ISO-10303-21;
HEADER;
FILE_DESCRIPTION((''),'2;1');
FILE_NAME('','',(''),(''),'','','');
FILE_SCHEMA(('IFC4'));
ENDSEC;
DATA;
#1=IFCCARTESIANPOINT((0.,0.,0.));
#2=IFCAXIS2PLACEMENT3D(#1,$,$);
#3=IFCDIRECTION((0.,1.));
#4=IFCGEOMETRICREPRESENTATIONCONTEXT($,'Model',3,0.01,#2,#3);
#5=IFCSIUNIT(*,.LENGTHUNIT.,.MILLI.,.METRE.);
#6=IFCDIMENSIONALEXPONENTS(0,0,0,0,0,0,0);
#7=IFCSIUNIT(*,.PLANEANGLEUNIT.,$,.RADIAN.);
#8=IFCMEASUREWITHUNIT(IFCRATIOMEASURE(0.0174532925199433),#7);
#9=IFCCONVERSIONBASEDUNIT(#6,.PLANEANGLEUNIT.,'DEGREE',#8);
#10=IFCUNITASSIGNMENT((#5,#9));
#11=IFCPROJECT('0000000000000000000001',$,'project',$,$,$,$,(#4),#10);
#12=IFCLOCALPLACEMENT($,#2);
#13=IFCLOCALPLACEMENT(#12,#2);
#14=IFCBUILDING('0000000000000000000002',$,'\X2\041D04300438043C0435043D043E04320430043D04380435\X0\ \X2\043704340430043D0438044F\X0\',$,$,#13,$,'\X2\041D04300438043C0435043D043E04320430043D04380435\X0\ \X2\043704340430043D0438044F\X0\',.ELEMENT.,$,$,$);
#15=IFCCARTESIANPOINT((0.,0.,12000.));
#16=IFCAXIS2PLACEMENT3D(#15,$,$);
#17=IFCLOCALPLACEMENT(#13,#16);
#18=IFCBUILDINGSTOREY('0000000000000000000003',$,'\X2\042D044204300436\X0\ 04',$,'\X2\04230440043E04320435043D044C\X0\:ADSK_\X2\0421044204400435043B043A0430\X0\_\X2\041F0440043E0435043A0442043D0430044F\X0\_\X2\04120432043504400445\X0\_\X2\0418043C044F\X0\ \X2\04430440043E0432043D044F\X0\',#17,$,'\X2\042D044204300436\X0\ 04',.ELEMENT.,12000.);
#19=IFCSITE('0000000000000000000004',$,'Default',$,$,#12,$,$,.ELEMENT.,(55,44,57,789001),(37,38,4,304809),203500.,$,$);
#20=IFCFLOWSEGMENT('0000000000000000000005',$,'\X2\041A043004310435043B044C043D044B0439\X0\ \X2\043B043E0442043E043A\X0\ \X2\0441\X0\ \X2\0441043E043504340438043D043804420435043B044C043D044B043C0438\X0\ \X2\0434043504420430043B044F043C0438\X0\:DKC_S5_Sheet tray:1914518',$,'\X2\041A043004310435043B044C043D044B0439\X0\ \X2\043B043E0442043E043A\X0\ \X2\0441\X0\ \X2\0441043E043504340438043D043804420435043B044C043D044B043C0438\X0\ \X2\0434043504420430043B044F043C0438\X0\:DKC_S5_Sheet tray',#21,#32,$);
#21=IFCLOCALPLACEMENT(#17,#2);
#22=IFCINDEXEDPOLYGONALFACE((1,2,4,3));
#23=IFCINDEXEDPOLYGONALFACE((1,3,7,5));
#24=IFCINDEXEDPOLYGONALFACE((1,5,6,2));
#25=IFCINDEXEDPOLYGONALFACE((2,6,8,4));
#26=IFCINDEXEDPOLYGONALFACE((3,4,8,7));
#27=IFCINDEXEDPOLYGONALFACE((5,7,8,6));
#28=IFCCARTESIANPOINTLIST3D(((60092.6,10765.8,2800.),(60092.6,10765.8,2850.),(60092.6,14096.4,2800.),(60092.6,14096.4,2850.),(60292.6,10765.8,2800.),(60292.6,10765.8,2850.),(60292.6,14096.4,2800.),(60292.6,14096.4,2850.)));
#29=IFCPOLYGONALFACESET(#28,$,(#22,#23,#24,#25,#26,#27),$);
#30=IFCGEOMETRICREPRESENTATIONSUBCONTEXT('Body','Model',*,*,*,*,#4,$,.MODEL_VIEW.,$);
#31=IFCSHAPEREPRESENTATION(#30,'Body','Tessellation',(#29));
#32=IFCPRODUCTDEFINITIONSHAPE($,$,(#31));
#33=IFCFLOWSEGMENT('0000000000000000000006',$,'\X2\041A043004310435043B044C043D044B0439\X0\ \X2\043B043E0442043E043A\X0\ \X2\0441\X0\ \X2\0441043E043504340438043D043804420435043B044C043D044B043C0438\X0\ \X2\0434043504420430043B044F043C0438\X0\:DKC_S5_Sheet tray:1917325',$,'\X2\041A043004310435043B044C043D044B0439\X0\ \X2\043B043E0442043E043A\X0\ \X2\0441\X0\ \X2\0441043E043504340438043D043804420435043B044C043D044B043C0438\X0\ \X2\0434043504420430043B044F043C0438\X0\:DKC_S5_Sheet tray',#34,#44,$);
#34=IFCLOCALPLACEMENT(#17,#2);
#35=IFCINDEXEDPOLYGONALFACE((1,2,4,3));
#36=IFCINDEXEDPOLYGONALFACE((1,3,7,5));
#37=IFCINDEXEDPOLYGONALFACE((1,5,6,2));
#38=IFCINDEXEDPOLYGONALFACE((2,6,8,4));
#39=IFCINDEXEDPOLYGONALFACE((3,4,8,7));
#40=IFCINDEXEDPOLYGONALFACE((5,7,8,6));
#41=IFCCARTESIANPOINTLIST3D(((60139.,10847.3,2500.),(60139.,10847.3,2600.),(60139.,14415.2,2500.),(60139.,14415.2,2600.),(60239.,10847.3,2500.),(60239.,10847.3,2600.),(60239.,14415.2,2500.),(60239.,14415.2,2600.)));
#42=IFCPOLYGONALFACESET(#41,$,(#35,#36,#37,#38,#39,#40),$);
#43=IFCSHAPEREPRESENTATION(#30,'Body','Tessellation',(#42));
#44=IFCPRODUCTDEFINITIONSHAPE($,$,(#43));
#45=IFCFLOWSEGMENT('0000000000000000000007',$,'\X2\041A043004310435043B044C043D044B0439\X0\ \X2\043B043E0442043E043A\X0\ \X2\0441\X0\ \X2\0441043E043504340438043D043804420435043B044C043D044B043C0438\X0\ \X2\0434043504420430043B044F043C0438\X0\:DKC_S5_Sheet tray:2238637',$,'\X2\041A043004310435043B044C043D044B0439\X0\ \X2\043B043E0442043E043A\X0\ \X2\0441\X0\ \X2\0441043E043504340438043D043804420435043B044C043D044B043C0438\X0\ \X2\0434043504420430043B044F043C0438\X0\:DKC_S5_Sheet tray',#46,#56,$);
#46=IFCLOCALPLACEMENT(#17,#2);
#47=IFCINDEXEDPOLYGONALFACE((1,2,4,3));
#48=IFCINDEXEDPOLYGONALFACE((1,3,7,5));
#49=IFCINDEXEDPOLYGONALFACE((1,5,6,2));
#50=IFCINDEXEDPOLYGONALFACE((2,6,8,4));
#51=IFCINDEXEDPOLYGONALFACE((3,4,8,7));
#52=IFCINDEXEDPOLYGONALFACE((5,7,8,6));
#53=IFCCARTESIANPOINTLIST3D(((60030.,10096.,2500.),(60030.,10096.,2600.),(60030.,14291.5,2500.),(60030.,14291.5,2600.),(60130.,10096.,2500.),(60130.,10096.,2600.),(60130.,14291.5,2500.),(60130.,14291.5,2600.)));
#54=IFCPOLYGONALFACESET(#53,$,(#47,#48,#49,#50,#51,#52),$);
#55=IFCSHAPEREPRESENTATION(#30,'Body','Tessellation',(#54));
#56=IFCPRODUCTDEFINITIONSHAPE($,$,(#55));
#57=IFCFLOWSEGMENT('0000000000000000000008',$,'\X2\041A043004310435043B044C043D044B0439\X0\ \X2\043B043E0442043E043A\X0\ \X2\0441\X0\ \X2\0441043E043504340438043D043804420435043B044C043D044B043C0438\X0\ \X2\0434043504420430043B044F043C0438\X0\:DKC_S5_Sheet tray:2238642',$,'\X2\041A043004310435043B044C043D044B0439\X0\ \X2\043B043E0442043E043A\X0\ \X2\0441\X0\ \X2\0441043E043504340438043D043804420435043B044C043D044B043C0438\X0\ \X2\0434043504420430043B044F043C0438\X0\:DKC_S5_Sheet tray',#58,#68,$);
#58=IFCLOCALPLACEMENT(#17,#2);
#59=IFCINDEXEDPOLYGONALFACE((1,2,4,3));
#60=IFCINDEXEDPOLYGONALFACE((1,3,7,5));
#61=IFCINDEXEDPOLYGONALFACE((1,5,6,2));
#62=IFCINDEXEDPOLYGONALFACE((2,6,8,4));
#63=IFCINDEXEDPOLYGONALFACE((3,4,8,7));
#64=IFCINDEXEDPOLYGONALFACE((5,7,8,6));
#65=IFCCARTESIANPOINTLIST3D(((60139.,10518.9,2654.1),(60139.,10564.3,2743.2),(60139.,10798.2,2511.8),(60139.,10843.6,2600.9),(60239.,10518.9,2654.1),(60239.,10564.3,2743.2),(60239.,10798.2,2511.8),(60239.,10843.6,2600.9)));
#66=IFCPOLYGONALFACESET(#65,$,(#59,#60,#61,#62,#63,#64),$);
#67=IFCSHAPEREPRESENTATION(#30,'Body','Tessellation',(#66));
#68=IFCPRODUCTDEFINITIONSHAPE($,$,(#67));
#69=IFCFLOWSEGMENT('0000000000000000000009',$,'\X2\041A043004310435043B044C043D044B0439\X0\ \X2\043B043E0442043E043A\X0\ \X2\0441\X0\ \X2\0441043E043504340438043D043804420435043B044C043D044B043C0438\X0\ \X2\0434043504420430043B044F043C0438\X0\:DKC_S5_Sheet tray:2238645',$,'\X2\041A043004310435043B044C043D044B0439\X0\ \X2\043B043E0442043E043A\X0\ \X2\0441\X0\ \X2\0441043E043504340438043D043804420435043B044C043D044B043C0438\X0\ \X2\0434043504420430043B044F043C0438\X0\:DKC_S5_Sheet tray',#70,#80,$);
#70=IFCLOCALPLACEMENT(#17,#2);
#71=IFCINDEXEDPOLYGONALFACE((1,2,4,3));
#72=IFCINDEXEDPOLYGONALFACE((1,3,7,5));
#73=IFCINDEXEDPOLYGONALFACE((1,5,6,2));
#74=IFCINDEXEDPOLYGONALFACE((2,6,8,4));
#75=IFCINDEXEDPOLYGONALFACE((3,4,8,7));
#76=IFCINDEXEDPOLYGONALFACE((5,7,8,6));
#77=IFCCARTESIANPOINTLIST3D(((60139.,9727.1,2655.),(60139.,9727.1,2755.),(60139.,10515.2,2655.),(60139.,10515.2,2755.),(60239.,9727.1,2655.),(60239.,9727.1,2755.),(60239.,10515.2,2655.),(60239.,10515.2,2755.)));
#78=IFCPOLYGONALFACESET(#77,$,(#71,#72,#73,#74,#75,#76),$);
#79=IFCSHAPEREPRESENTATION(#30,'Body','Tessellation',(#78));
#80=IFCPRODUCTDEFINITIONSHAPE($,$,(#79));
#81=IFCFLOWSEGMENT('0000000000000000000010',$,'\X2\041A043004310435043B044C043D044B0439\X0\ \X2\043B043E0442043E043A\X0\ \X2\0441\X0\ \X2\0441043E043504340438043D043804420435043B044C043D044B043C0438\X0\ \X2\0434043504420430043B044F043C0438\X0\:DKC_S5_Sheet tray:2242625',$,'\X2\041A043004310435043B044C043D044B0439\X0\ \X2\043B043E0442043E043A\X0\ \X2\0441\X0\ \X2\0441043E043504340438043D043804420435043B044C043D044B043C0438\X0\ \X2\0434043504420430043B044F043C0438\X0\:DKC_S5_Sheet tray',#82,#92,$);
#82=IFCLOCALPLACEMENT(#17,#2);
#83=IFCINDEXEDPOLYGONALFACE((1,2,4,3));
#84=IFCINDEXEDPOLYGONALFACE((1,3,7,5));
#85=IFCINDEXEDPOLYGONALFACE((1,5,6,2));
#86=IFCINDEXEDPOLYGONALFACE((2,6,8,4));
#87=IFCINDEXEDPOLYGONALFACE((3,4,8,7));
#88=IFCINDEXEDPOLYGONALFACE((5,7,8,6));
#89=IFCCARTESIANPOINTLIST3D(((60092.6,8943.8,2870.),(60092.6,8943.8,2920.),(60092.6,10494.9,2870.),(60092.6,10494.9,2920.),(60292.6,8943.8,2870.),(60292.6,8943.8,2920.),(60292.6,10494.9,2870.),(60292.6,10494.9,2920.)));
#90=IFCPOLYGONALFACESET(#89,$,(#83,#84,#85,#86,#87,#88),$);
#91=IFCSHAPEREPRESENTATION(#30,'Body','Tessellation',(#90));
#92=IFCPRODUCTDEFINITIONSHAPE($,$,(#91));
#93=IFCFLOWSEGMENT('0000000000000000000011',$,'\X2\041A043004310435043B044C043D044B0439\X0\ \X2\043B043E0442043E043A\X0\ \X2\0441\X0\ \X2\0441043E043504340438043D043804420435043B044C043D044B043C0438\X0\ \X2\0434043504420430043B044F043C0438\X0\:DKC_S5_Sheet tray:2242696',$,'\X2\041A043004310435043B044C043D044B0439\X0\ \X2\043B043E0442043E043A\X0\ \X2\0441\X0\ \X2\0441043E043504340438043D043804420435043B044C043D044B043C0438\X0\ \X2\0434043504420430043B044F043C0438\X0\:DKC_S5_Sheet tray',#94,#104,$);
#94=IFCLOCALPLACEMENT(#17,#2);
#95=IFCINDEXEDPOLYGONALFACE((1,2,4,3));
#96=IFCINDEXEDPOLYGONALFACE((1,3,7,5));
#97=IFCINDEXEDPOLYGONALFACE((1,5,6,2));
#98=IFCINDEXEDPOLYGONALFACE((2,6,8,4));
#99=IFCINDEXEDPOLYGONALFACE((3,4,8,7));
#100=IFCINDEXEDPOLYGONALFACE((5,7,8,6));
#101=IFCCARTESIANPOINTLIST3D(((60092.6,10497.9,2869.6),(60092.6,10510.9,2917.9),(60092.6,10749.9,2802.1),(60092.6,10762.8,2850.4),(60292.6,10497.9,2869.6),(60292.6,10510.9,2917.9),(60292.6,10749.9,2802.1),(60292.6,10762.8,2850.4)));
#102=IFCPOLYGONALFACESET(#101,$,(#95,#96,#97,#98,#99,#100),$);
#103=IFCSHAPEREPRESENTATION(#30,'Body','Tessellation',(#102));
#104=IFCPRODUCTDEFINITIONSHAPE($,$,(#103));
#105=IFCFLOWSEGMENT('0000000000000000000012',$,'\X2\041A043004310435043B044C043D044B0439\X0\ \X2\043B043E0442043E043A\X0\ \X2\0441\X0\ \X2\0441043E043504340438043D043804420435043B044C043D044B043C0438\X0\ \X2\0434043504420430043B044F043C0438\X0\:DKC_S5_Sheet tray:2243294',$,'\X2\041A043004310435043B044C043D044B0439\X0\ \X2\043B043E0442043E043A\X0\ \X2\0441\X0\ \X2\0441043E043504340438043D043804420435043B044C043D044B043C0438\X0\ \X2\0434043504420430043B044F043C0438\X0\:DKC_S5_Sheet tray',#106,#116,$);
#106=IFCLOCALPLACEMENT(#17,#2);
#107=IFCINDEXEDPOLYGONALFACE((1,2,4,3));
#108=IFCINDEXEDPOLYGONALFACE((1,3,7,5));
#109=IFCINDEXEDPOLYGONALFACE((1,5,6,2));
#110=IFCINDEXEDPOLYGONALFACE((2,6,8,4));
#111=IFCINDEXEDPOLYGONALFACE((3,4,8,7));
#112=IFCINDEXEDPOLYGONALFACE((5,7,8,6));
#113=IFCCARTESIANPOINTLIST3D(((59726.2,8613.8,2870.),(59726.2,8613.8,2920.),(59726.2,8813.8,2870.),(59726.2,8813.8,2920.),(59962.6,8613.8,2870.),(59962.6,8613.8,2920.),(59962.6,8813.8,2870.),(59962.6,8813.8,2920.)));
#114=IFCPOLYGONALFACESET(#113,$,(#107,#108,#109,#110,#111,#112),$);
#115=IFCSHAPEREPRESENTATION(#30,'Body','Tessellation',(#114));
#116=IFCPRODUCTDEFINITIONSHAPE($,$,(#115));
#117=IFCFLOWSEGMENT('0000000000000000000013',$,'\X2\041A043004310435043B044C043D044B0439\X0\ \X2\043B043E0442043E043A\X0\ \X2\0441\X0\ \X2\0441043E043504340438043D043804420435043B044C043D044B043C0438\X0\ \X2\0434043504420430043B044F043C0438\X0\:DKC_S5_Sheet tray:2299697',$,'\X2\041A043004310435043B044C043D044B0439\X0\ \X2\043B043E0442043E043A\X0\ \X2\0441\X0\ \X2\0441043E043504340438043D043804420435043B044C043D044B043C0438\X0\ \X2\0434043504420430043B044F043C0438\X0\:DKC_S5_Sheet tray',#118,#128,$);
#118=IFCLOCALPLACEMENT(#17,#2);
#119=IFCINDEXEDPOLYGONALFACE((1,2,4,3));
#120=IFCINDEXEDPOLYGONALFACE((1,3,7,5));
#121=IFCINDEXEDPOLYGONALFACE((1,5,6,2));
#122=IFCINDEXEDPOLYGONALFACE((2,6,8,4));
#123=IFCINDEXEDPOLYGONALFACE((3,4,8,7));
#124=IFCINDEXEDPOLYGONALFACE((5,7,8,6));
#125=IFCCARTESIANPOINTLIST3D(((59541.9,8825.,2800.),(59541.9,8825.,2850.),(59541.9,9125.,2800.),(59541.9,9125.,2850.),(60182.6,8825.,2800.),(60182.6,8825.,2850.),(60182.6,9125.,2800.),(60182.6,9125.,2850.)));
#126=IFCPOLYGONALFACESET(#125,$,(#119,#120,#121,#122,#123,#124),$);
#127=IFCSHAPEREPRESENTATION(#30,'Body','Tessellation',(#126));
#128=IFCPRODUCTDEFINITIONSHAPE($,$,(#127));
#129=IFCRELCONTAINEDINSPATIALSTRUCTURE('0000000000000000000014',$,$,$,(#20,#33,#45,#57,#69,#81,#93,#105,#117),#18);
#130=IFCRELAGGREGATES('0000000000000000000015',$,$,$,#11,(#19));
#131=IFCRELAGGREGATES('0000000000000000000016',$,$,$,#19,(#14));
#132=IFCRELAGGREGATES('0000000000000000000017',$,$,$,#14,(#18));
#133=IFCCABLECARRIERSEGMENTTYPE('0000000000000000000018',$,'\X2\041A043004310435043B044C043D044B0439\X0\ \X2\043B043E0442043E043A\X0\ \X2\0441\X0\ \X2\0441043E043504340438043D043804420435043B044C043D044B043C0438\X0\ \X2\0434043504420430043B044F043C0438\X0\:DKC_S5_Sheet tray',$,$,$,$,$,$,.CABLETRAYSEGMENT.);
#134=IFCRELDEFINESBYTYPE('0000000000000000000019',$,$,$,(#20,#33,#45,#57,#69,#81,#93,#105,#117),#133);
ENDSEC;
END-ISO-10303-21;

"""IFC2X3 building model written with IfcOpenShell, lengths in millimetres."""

from ifc_helpers import new_model, entity, si_unit, converted_unit, direction, frame, frame_2d, origin, origin_2d_with_axis, place, context, subcontext, project, spatial, rectangle, extrude, type_object, element, save


model = new_model("IFC2X3")

# Units and contexts
model_context = context("Model", 3, precision=0.01, world=origin(), true_north=direction((0.0, 1.0)))
body_context = subcontext(model_context, "Body", "Model", "MODEL_VIEW")
ifc_project = project(units=[si_unit("LENGTHUNIT", "METRE", prefix="MILLI"), converted_unit("PLANEANGLEUNIT", "DEGREE", entity("IfcRatioMeasure", 0.0174532925199433), si_unit("PLANEANGLEUNIT", "RADIAN"), dimensions=[0, 0, 0, 0, 0, 0, 0])], contexts=[model_context])

# Site, building, storey
site_placement = place(None, origin())
site = spatial("IfcSite", under=ifc_project, at=site_placement, Name="Default", CompositionType="ELEMENT", RefLatitude=(55, 44, 57, 789001), RefLongitude=(37, 38, 4, 304809), RefElevation=203500.0)
building_placement = place(site_placement, origin())
building = spatial("IfcBuilding", under=site, at=building_placement, Name="Наименование здания", LongName="Наименование здания", CompositionType="ELEMENT")
storey_placement = place(building_placement, frame((0.0, 0.0, 12000.0)))
storey = spatial("IfcBuildingStorey", under=building, at=storey_placement, Name="Этаж 04", ObjectType="Уровень:ADSK_Стрелка_Проектная_Вверх_Имя уровня", LongName="Этаж 04", CompositionType="ELEMENT", Elevation=12000.0)

# Flow segments
cable_carrier_segment_type = type_object("IfcCableCarrierSegmentType", Name="Кабельный лоток с соединительными деталями:DKC_S5_Sheet tray", PredefinedType="CABLETRAYSEGMENT")
flow_segment_1_placement = place(storey_placement, frame((60092.6, 10765.8, 2800.0)))
element("IfcFlowSegment", 1, at=flow_segment_1_placement, inside=storey, type_object=cable_carrier_segment_type, Name="Кабельный лоток с соединительными деталями:DKC_S5_Sheet tray:1914518", ObjectType="Кабельный лоток с соединительными деталями:DKC_S5_Sheet tray", context=body_context, shape_type="SweptSolid", body=[
    extrude(rectangle(XDim=3330.5, YDim=200.0, at=origin_2d_with_axis()), frame((100.0, 1665.3, 0.0), z_axis=(0.0, 0.0, 1.0), x_axis=(0.0, 1.0, 0.0)), (0.0, 0.0, 1.0), 50.0),
])
flow_segment_2_placement = place(storey_placement, frame((60139.0, 10847.3, 2500.0)))
element("IfcFlowSegment", 2, at=flow_segment_2_placement, inside=storey, type_object=cable_carrier_segment_type, Name="Кабельный лоток с соединительными деталями:DKC_S5_Sheet tray:1917325", ObjectType="Кабельный лоток с соединительными деталями:DKC_S5_Sheet tray", context=body_context, shape_type="SweptSolid", body=[
    extrude(rectangle(XDim=3567.9, YDim=100.0, at=origin_2d_with_axis()), frame((50.0, 1784.0, 0.0), z_axis=(0.0, 0.0, 1.0), x_axis=(0.0, 1.0, 0.0)), (0.0, 0.0, 1.0), 100.0),
])
flow_segment_3_placement = place(storey_placement, frame((60030.0, 10096.0, 2500.0)))
element("IfcFlowSegment", 3, at=flow_segment_3_placement, inside=storey, type_object=cable_carrier_segment_type, Name="Кабельный лоток с соединительными деталями:DKC_S5_Sheet tray:2238637", ObjectType="Кабельный лоток с соединительными деталями:DKC_S5_Sheet tray", context=body_context, shape_type="SweptSolid", body=[
    extrude(rectangle(XDim=4195.5, YDim=100.0, at=origin_2d_with_axis()), frame((50.0, 2097.8, 0.0), z_axis=(0.0, 0.0, 1.0), x_axis=(0.0, -1.0, 0.0)), (0.0, 0.0, 1.0), 100.0),
])
flow_segment_4_placement = place(storey_placement, frame((60139.0, 10518.9, 2511.8)))
element("IfcFlowSegment", 4, at=flow_segment_4_placement, inside=storey, type_object=cable_carrier_segment_type, Name="Кабельный лоток с соединительными деталями:DKC_S5_Sheet tray:2238642", ObjectType="Кабельный лоток с соединительными деталями:DKC_S5_Sheet tray", context=body_context, shape_type="SweptSolid", body=[
    extrude(rectangle(XDim=100.0, YDim=313.5, at=frame_2d((0.0, 0.0), x_axis=(0.0, 1.0))), frame((0.0, 162.4, 115.7), z_axis=(1.0, 0.0, 0.0), x_axis=(0.0, -0.891007, 0.45399)), (0.0, 0.0, 1.0), 100.0),
])
flow_segment_5_placement = place(storey_placement, frame((60139.0, 9727.1, 2655.0)))
element("IfcFlowSegment", 5, at=flow_segment_5_placement, inside=storey, type_object=cable_carrier_segment_type, Name="Кабельный лоток с соединительными деталями:DKC_S5_Sheet tray:2238645", ObjectType="Кабельный лоток с соединительными деталями:DKC_S5_Sheet tray", context=body_context, shape_type="SweptSolid", body=[
    extrude(rectangle(XDim=788.0, YDim=100.0, at=origin_2d_with_axis()), frame((50.0, 394.0, 0.0), z_axis=(0.0, 0.0, 1.0), x_axis=(0.0, -1.0, 0.0)), (0.0, 0.0, 1.0), 100.0),
])
flow_segment_6_placement = place(storey_placement, frame((60092.6, 8943.8, 2870.0)))
element("IfcFlowSegment", 6, at=flow_segment_6_placement, inside=storey, type_object=cable_carrier_segment_type, Name="Кабельный лоток с соединительными деталями:DKC_S5_Sheet tray:2242625", ObjectType="Кабельный лоток с соединительными деталями:DKC_S5_Sheet tray", context=body_context, shape_type="SweptSolid", body=[
    extrude(rectangle(XDim=1551.1, YDim=200.0, at=origin_2d_with_axis()), frame((100.0, 775.6, 0.0), z_axis=(0.0, 0.0, 1.0), x_axis=(0.0, 1.0, 0.0)), (0.0, 0.0, 1.0), 50.0),
])
flow_segment_7_placement = place(storey_placement, frame((60092.6, 10497.9, 2802.1)))
element("IfcFlowSegment", 7, at=flow_segment_7_placement, inside=storey, type_object=cable_carrier_segment_type, Name="Кабельный лоток с соединительными деталями:DKC_S5_Sheet tray:2242696", ObjectType="Кабельный лоток с соединительными деталями:DKC_S5_Sheet tray", context=body_context, shape_type="SweptSolid", body=[
    extrude(rectangle(XDim=50.0, YDim=260.8, at=frame_2d((0.0, 0.0), x_axis=(0.0, 1.0))), frame((0.0, 132.4, 57.9), z_axis=(1.0, 0.0, 0.0), x_axis=(0.0, -0.965926, 0.258819)), (0.0, 0.0, 1.0), 200.0),
])
flow_segment_8_placement = place(storey_placement, frame((59726.2, 8613.8, 2870.0)))
element("IfcFlowSegment", 8, at=flow_segment_8_placement, inside=storey, type_object=cable_carrier_segment_type, Name="Кабельный лоток с соединительными деталями:DKC_S5_Sheet tray:2243294", ObjectType="Кабельный лоток с соединительными деталями:DKC_S5_Sheet tray", context=body_context, shape_type="SweptSolid", body=[
    extrude(rectangle(XDim=236.4, YDim=200.0, at=origin_2d_with_axis()), frame((118.2, 100.0, 0.0)), (0.0, 0.0, 1.0), 50.0),
])
flow_segment_9_placement = place(storey_placement, frame((59541.9, 8825.0, 2800.0)))
element("IfcFlowSegment", 9, at=flow_segment_9_placement, inside=storey, type_object=cable_carrier_segment_type, Name="Кабельный лоток с соединительными деталями:DKC_S5_Sheet tray:2299697", ObjectType="Кабельный лоток с соединительными деталями:DKC_S5_Sheet tray", context=body_context, shape_type="SweptSolid", body=[
    extrude(rectangle(XDim=640.7, YDim=300.0, at=origin_2d_with_axis()), frame((320.3, 150.0, 0.0), z_axis=(0.0, 0.0, 1.0), x_axis=(-1.0, 0.0, 0.0)), (0.0, 0.0, 1.0), 50.0),
])

save(model, "model.ifc")
